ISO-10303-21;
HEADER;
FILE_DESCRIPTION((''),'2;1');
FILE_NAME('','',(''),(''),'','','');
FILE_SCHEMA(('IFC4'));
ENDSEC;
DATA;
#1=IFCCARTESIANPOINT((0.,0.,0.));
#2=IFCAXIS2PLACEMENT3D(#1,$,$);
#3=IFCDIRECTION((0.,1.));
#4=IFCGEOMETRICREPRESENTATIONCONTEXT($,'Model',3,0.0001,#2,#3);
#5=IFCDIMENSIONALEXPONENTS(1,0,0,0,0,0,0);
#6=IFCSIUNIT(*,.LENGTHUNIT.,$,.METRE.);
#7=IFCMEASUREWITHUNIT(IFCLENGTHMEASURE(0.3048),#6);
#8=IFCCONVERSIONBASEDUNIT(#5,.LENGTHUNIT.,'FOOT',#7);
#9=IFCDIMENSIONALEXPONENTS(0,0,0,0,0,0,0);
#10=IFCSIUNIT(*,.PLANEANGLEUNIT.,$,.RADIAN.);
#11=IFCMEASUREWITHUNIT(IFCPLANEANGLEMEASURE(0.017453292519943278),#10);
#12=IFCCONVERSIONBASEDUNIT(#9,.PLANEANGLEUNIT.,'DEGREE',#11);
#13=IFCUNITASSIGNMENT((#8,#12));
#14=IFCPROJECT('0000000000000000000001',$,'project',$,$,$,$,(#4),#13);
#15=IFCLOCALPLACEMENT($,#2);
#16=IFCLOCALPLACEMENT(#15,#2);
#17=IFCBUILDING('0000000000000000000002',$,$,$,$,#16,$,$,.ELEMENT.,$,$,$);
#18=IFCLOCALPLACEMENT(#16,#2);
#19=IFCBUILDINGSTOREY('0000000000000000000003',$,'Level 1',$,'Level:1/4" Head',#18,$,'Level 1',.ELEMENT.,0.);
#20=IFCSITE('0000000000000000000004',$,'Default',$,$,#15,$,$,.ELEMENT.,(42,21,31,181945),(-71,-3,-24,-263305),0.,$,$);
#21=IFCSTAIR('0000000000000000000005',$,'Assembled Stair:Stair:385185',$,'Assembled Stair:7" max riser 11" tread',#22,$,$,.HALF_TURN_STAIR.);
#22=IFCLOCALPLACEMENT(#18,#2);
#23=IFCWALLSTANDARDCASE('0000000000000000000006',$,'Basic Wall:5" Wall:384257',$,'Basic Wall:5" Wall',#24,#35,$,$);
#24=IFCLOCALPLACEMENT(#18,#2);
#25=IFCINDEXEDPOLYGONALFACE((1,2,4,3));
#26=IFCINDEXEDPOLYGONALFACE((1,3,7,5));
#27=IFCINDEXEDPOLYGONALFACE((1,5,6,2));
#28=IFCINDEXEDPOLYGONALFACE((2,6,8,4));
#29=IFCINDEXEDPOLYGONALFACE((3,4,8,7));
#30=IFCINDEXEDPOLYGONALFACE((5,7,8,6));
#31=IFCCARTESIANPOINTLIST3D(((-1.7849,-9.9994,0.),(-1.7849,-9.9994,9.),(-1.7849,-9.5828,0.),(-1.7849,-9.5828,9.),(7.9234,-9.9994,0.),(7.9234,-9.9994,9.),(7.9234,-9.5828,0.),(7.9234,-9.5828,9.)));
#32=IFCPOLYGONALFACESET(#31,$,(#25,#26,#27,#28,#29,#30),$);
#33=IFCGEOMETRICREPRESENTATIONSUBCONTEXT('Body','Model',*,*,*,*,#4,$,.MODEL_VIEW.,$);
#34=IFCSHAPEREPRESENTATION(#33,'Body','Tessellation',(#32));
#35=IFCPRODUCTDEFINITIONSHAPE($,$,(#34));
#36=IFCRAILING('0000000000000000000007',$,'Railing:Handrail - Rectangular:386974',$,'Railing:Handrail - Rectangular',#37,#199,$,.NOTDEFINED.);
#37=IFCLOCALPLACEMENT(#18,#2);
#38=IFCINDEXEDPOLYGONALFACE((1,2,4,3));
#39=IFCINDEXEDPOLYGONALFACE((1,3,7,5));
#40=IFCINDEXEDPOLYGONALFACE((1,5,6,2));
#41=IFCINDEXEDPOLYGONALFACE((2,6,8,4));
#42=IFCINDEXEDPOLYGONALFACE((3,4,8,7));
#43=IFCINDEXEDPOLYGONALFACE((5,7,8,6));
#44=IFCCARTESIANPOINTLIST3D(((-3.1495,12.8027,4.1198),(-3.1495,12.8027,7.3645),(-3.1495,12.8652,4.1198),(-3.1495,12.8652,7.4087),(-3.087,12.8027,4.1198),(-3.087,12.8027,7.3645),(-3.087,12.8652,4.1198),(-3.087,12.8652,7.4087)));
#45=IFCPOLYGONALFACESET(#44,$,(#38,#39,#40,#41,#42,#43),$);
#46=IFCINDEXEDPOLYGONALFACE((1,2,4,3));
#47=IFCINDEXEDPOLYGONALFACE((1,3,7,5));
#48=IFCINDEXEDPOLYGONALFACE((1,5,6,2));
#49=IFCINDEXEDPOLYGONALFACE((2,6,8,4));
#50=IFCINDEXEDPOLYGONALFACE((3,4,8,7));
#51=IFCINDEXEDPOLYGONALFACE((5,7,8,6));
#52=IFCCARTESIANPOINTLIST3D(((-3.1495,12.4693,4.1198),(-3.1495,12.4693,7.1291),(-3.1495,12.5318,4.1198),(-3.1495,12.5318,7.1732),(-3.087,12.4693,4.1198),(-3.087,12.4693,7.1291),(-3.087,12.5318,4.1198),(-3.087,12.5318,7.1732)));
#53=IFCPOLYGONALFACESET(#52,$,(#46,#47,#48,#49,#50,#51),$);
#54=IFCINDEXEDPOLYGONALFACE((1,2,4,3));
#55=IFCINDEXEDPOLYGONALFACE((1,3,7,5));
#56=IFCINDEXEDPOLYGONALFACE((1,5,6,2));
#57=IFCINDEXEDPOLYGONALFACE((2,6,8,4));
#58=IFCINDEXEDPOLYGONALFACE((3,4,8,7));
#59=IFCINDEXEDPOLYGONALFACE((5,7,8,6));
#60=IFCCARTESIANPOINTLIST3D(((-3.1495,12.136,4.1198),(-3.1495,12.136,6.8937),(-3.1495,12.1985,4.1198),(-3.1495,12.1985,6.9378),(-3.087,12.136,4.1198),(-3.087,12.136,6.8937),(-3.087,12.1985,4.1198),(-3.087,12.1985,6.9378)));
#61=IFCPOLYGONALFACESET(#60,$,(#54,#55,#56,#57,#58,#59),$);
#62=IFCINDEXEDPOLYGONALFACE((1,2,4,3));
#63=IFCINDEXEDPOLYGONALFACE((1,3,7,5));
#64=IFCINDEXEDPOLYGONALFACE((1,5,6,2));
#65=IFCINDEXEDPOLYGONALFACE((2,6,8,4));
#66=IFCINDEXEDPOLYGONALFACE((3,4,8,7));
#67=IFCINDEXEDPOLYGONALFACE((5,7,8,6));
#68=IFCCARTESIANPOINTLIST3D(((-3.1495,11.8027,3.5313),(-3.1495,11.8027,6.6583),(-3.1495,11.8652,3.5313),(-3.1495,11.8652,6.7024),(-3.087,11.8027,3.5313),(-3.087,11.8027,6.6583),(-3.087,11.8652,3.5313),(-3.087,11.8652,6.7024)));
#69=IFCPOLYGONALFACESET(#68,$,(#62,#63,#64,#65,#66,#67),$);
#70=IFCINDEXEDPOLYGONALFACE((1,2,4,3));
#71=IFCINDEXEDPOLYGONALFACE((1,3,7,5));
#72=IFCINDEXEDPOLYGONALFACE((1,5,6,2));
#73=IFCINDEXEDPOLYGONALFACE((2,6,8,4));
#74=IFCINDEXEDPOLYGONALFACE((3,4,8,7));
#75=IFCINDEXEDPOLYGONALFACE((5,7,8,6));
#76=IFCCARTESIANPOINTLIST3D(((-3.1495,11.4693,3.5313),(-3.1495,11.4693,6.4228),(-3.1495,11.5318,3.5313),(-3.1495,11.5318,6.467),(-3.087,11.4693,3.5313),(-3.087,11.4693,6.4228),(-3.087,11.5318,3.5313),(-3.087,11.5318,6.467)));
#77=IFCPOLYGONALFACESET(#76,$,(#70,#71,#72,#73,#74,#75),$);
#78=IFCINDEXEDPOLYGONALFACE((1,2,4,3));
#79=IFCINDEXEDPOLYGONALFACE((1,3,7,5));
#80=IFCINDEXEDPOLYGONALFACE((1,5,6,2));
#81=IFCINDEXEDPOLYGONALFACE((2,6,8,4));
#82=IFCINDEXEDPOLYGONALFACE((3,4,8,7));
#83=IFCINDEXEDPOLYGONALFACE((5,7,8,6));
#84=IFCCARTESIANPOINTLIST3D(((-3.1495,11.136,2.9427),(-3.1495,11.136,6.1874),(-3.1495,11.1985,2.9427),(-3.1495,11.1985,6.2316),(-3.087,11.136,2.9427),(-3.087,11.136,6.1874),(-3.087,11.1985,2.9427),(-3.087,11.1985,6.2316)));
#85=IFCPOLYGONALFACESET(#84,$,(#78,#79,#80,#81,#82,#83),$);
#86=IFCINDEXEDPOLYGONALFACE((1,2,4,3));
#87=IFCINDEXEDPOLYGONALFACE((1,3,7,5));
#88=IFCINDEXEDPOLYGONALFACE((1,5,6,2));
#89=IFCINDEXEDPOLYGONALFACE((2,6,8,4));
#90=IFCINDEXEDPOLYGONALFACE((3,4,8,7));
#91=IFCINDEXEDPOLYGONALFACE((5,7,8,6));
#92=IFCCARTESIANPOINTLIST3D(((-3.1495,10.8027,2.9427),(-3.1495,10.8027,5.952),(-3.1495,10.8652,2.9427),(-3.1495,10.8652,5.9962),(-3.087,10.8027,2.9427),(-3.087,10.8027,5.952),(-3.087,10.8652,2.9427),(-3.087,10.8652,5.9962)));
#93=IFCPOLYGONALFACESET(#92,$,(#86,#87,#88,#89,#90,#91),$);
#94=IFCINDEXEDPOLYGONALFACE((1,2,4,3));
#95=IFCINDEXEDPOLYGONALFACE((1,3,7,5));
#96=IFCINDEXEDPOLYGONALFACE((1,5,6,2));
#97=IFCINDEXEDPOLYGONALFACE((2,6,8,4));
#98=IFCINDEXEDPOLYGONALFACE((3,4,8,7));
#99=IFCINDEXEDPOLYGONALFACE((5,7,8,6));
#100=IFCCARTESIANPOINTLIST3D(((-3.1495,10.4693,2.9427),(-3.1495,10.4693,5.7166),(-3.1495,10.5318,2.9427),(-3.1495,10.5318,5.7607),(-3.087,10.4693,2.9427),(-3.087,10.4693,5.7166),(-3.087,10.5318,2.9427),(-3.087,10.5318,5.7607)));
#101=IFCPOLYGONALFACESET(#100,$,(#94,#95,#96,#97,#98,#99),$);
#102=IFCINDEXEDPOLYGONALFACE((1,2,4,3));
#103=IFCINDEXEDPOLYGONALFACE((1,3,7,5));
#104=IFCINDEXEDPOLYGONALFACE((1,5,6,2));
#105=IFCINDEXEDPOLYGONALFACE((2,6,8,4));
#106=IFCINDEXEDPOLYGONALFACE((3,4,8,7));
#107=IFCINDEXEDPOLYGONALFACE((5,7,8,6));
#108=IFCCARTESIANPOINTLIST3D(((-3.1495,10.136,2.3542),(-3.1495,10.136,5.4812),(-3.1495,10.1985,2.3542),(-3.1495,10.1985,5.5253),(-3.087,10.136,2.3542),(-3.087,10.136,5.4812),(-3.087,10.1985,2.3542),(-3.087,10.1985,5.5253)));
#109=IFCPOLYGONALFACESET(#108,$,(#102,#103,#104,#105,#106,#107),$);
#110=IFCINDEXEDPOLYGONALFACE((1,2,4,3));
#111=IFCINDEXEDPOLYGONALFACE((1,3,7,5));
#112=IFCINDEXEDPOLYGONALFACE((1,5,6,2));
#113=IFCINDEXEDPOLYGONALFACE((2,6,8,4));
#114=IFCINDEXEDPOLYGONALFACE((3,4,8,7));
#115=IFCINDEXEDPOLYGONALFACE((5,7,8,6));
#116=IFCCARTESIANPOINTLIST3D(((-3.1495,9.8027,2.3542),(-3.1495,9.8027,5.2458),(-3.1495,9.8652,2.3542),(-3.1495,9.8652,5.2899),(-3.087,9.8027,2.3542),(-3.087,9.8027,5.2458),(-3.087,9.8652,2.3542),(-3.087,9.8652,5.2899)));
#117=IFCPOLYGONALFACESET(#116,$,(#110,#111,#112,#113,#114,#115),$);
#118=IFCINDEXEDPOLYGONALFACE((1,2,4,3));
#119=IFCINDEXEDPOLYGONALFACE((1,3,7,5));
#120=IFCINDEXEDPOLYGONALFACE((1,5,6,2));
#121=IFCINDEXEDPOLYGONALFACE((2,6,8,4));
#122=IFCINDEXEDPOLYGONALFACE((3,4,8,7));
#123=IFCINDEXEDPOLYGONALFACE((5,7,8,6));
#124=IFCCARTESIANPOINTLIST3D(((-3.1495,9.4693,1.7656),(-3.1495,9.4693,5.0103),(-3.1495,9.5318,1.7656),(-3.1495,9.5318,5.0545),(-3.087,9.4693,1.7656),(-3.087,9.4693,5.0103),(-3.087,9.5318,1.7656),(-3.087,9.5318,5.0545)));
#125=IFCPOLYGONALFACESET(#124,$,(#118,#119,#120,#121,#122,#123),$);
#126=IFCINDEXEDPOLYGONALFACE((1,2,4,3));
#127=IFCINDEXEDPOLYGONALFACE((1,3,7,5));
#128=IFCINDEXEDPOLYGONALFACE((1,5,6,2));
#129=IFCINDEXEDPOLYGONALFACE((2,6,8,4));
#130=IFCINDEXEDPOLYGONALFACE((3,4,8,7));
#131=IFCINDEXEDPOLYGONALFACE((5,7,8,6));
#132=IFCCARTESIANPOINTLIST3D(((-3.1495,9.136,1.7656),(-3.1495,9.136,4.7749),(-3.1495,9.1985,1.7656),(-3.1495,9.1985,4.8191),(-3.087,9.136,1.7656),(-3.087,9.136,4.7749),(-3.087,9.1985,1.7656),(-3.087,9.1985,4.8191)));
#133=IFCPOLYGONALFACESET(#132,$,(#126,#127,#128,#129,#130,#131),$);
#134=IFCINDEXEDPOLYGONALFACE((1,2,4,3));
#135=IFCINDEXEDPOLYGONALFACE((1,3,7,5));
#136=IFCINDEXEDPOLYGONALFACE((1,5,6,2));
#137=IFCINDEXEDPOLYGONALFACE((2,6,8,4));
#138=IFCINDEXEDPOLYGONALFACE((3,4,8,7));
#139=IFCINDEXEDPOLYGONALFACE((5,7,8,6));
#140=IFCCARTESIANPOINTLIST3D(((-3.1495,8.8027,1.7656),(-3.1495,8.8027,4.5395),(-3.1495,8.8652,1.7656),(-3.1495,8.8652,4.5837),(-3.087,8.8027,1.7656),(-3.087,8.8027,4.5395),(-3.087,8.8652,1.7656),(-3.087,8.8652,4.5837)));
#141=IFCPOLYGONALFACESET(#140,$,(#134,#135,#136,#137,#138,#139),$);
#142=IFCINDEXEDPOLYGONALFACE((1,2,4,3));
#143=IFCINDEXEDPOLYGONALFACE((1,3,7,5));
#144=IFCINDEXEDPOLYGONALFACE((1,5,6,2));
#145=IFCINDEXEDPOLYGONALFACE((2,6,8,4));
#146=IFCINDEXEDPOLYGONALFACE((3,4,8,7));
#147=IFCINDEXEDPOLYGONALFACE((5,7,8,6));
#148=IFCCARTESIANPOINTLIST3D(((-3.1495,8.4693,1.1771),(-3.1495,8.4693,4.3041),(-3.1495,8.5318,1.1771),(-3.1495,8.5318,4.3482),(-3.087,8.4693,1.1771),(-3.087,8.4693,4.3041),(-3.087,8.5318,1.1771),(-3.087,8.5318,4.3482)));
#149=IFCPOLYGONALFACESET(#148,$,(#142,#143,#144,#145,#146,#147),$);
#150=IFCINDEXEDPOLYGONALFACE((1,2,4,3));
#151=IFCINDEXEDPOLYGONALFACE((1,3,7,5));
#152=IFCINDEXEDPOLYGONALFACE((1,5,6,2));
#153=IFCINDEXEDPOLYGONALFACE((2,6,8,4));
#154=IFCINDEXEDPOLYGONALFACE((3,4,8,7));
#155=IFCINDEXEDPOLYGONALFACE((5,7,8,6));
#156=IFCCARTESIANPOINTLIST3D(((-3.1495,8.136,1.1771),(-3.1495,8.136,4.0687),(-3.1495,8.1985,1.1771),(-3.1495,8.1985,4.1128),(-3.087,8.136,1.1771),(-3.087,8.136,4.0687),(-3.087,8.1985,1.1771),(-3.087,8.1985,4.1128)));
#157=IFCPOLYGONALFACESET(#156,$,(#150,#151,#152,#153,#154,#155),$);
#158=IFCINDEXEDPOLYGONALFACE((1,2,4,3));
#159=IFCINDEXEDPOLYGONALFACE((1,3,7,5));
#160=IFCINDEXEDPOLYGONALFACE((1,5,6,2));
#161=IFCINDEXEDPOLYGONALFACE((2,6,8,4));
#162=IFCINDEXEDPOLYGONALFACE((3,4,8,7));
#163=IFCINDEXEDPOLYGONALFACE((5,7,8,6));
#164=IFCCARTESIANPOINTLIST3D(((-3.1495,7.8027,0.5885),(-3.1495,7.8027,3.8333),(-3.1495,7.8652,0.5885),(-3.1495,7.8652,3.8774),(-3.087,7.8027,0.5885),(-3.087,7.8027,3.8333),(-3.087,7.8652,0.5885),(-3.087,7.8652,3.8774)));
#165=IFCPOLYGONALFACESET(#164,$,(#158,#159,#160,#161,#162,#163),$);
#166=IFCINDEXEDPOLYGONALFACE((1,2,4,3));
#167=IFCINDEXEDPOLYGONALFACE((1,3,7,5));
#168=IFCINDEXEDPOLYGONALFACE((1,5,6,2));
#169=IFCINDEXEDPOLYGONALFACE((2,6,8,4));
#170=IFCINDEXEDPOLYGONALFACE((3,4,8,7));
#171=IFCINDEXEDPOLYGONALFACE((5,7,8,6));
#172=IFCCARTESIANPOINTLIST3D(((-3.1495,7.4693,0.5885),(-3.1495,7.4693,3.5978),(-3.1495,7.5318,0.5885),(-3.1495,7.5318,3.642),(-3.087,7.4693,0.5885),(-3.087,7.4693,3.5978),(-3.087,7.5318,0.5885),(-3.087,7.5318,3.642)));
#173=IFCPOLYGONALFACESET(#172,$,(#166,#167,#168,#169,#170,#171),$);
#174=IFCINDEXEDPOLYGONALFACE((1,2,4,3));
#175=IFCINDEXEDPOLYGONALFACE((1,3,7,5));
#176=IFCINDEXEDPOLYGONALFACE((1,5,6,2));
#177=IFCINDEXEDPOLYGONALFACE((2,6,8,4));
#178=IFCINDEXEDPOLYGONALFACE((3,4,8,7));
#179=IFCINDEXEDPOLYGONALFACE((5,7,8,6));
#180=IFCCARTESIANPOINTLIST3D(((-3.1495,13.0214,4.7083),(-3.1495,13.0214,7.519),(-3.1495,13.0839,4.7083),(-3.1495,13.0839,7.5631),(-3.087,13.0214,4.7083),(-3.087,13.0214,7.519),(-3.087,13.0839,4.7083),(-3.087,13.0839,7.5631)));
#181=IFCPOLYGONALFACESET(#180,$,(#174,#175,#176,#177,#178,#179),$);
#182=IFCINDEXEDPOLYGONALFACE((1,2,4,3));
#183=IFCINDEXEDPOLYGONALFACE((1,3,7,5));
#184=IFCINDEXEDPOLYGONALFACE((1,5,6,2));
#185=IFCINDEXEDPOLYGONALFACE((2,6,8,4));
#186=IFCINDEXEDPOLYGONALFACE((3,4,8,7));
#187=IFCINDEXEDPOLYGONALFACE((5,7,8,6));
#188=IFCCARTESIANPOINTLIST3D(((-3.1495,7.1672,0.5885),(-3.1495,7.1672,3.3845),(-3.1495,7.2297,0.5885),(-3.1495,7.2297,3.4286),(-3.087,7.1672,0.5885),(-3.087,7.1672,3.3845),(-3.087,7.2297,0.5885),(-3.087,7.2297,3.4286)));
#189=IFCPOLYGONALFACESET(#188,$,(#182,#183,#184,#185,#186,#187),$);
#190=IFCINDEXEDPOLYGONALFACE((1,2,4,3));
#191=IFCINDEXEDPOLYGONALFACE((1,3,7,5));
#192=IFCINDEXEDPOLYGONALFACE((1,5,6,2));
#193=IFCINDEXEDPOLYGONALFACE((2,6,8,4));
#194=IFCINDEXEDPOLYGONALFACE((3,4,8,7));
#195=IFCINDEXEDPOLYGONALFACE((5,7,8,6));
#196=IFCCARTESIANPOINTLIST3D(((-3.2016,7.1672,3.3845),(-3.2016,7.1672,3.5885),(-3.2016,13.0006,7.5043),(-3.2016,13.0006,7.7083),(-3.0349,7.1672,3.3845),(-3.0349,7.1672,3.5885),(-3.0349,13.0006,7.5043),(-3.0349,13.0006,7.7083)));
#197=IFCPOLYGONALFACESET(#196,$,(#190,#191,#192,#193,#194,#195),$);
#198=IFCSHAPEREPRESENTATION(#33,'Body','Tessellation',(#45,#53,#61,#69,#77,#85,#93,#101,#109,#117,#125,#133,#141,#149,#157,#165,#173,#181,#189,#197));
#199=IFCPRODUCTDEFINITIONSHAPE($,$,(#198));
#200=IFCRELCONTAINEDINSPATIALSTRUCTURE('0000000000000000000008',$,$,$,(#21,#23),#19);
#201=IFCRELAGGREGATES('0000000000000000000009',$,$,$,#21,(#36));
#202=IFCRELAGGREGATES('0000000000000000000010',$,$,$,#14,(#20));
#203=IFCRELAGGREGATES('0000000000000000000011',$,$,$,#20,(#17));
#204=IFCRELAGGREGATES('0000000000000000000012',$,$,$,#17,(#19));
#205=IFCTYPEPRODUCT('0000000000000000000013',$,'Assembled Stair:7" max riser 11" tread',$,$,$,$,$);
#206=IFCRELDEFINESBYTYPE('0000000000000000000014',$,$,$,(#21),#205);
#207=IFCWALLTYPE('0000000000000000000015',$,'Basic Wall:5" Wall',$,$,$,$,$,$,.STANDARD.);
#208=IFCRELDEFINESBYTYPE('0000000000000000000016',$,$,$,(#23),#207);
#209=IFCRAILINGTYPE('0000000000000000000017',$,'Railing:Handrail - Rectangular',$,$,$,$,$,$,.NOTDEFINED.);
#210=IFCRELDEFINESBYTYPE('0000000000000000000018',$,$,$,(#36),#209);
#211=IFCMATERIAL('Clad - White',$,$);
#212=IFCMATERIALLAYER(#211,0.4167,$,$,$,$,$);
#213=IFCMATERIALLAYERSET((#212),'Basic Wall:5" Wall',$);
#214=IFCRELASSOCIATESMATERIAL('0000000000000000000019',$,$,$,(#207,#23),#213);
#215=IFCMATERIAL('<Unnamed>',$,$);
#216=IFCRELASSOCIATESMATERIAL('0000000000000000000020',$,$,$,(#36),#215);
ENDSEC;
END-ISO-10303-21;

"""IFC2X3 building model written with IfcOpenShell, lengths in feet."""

from ifc_helpers import new_model, entity, si_unit, converted_unit, direction, frame, frame_2d, origin, place, context, subcontext, project, spatial, polyline, rectangle, outline, extrude, clip, bounded_halfspace, material, layer, layer_set, layer_usage, type_object, element, aggregate, save


model = new_model("IFC2X3")

# Units and contexts
model_context = context("Model", 3, precision=0.0001, world=origin(), true_north=direction((0.0, 1.0)))
body_context = subcontext(model_context, "Body", "Model", "MODEL_VIEW")
ifc_project = project(units=[converted_unit("LENGTHUNIT", "FOOT", entity("IfcLengthMeasure", 0.3048), si_unit("LENGTHUNIT", "METRE"), dimensions=[1, 0, 0, 0, 0, 0, 0]), converted_unit("PLANEANGLEUNIT", "DEGREE", entity("IfcPlaneAngleMeasure", 0.017453292519943278), si_unit("PLANEANGLEUNIT", "RADIAN"), dimensions=[0, 0, 0, 0, 0, 0, 0])], contexts=[model_context])

# Site, building, storey
site_placement = place(None, origin())
site = spatial("IfcSite", under=ifc_project, at=site_placement, Name="Default", CompositionType="ELEMENT", RefLatitude=(42, 21, 31, 181945), RefLongitude=(-71, -3, -24, -263305), RefElevation=0.0)
building_placement = place(site_placement, origin())
building = spatial("IfcBuilding", under=site, at=building_placement, CompositionType="ELEMENT")
storey_placement = place(building_placement, origin())
storey = spatial("IfcBuildingStorey", under=building, at=storey_placement, Name="Level 1", ObjectType="Level:1/4\" Head", LongName="Level 1", CompositionType="ELEMENT", Elevation=0.0)

# Stair
type_product = type_object("IfcTypeProduct", Name="Assembled Stair:7\" max riser 11\" tread")
stair_placement = place(storey_placement, origin())
stair = element("IfcStair", 1, at=stair_placement, inside=storey, type_object=type_product, Name="Assembled Stair:Stair:385185", ObjectType="Assembled Stair:7\" max riser 11\" tread", ShapeType="HALF_TURN_STAIR")
ifc_material_1 = material(Name="<Unnamed>")

# Shared definitions
ifc_material_2 = material(Name="Clad - White")

# Wall
ifc_layer_1 = layer(ifc_material_2, 0.4167)
ifc_layer_set_1 = layer_set([ifc_layer_1], Name="Basic Wall:5\" Wall")
ifc_layer_usage_1 = layer_usage(ifc_layer_set_1, "AXIS2", "NEGATIVE", 0.2083)
wall_type_1 = type_object("IfcWallType", Name="Basic Wall:5\" Wall", PredefinedType="STANDARD", material=ifc_layer_set_1)
wall_1_placement = place(storey_placement, frame((7.9234, -9.7911, 0.0), z_axis=(0.0, 0.0, 1.0), x_axis=(-1.0, 0.0, 0.0)))
element("IfcWallStandardCase", 2, at=wall_1_placement, inside=storey, type_object=wall_type_1, material=ifc_layer_usage_1, Name="Basic Wall:5\" Wall:384257", ObjectType="Basic Wall:5\" Wall", context=body_context, shape_type="Clipping", body=[
    clip(extrude(rectangle(XDim=9.7083, YDim=0.4167, at=frame_2d((4.8542, 0.0), x_axis=(-1.0, 0.0))), origin(), (0.0, 0.0, 1.0), 9.0), bounded_halfspace(frame((0.0, -0.2083, 9.0), z_axis=(0.0, 0.0, -1.0), x_axis=(0.0, 1.0, 0.0)), True, frame((0.0, -0.2083, 9.0)), polyline([(0.0, 0.0), (9.7083, 0.0), (9.7083, 0.4167), (0.0, 0.4167), (0.0, 0.0)]))),
])

# Railing
railing_type = type_object("IfcRailingType", Name="Railing:Handrail - Rectangular", PredefinedType="NOTDEFINED")
railing_1_placement = place(stair_placement, origin())
railing_1 = element("IfcRailing", 3, at=railing_1_placement, type_object=railing_type, material=ifc_material_1, Name="Railing:Handrail - Rectangular:386974", ObjectType="Railing:Handrail - Rectangular", PredefinedType="NOTDEFINED", context=body_context, shape_type="SweptSolid", body=[
    extrude(outline(polyline([(-1.6113, -0.0312), (1.6334, -0.0312), (1.6334, 0.0312), (-1.6555, 0.0312), (-1.6113, -0.0312)])), frame((-3.1495, 12.8339, 5.7532), z_axis=(1.0, 0.0, 0.0), x_axis=(0.0, 0.0, -1.0)), (0.0, 0.0, 1.0), 0.0625),
    extrude(outline(polyline([(-1.4936, -0.0312), (1.5157, -0.0312), (1.5157, 0.0312), (-1.5378, 0.0312), (-1.4936, -0.0312)])), frame((-3.1495, 12.5006, 5.6355), z_axis=(1.0, 0.0, 0.0), x_axis=(0.0, 0.0, -1.0)), (0.0, 0.0, 1.0), 0.0625),
    extrude(outline(polyline([(-1.3759, -0.0312), (1.398, -0.0312), (1.398, 0.0312), (-1.42, 0.0312), (-1.3759, -0.0312)])), frame((-3.1495, 12.1672, 5.5178), z_axis=(1.0, 0.0, 0.0), x_axis=(0.0, 0.0, -1.0)), (0.0, 0.0, 1.0), 0.0625),
    extrude(outline(polyline([(-1.5525, -0.0312), (1.5745, -0.0312), (1.5745, 0.0312), (-1.5966, 0.0312), (-1.5525, -0.0312)])), frame((-3.1495, 11.8339, 5.1058), z_axis=(1.0, 0.0, 0.0), x_axis=(0.0, 0.0, -1.0)), (0.0, 0.0, 1.0), 0.0625),
    extrude(outline(polyline([(-1.4348, -0.0312), (1.4568, -0.0312), (1.4568, 0.0312), (-1.4789, 0.0312), (-1.4348, -0.0312)])), frame((-3.1495, 11.5006, 4.9881), z_axis=(1.0, 0.0, 0.0), x_axis=(0.0, 0.0, -1.0)), (0.0, 0.0, 1.0), 0.0625),
    extrude(outline(polyline([(-1.6113, -0.0312), (1.6334, -0.0312), (1.6334, 0.0312), (-1.6555, 0.0312), (-1.6113, -0.0312)])), frame((-3.1495, 11.1672, 4.5761), z_axis=(1.0, 0.0, 0.0), x_axis=(0.0, 0.0, -1.0)), (0.0, 0.0, 1.0), 0.0625),
    extrude(outline(polyline([(-1.4936, -0.0312), (1.5157, -0.0312), (1.5157, 0.0312), (-1.5378, 0.0312), (-1.4936, -0.0312)])), frame((-3.1495, 10.8339, 4.4584), z_axis=(1.0, 0.0, 0.0), x_axis=(0.0, 0.0, -1.0)), (0.0, 0.0, 1.0), 0.0625),
    extrude(outline(polyline([(-1.3759, -0.0312), (1.398, -0.0312), (1.398, 0.0312), (-1.42, 0.0312), (-1.3759, -0.0312)])), frame((-3.1495, 10.5006, 4.3407), z_axis=(1.0, 0.0, 0.0), x_axis=(0.0, 0.0, -1.0)), (0.0, 0.0, 1.0), 0.0625),
    extrude(outline(polyline([(-1.5525, -0.0312), (1.5745, -0.0312), (1.5745, 0.0312), (-1.5966, 0.0312), (-1.5525, -0.0312)])), frame((-3.1495, 10.1672, 3.9287), z_axis=(1.0, 0.0, 0.0), x_axis=(0.0, 0.0, -1.0)), (0.0, 0.0, 1.0), 0.0625),
    extrude(outline(polyline([(-1.4348, -0.0312), (1.4568, -0.0312), (1.4568, 0.0312), (-1.4789, 0.0312), (-1.4348, -0.0312)])), frame((-3.1495, 9.8339, 3.811), z_axis=(1.0, 0.0, 0.0), x_axis=(0.0, 0.0, -1.0)), (0.0, 0.0, 1.0), 0.0625),
    extrude(outline(polyline([(-1.6113, -0.0312), (1.6334, -0.0312), (1.6334, 0.0312), (-1.6555, 0.0312), (-1.6113, -0.0312)])), frame((-3.1495, 9.5006, 3.399), z_axis=(1.0, 0.0, 0.0), x_axis=(0.0, 0.0, -1.0)), (0.0, 0.0, 1.0), 0.0625),
    extrude(outline(polyline([(-1.4936, -0.0312), (1.5157, -0.0312), (1.5157, 0.0312), (-1.5378, 0.0312), (-1.4936, -0.0312)])), frame((-3.1495, 9.1672, 3.2813), z_axis=(1.0, 0.0, 0.0), x_axis=(0.0, 0.0, -1.0)), (0.0, 0.0, 1.0), 0.0625),
    extrude(outline(polyline([(-1.3759, -0.0312), (1.398, -0.0312), (1.398, 0.0312), (-1.42, 0.0312), (-1.3759, -0.0312)])), frame((-3.1495, 8.8339, 3.1636), z_axis=(1.0, 0.0, 0.0), x_axis=(0.0, 0.0, -1.0)), (0.0, 0.0, 1.0), 0.0625),
    extrude(outline(polyline([(-1.5525, -0.0312), (1.5745, -0.0312), (1.5745, 0.0312), (-1.5966, 0.0312), (-1.5525, -0.0312)])), frame((-3.1495, 8.5006, 2.7516), z_axis=(1.0, 0.0, 0.0), x_axis=(0.0, 0.0, -1.0)), (0.0, 0.0, 1.0), 0.0625),
    extrude(outline(polyline([(-1.4348, -0.0312), (1.4568, -0.0312), (1.4568, 0.0312), (-1.4789, 0.0312), (-1.4348, -0.0312)])), frame((-3.1495, 8.1672, 2.6339), z_axis=(1.0, 0.0, 0.0), x_axis=(0.0, 0.0, -1.0)), (0.0, 0.0, 1.0), 0.0625),
    extrude(outline(polyline([(-1.6113, -0.0312), (1.6334, -0.0312), (1.6334, 0.0312), (-1.6555, 0.0312), (-1.6113, -0.0312)])), frame((-3.1495, 7.8339, 2.2219), z_axis=(1.0, 0.0, 0.0), x_axis=(0.0, 0.0, -1.0)), (0.0, 0.0, 1.0), 0.0625),
    extrude(outline(polyline([(-1.4936, -0.0312), (1.5157, -0.0312), (1.5157, 0.0312), (-1.5378, 0.0312), (-1.4936, -0.0312)])), frame((-3.1495, 7.5006, 2.1042), z_axis=(1.0, 0.0, 0.0), x_axis=(0.0, 0.0, -1.0)), (0.0, 0.0, 1.0), 0.0625),
    extrude(outline(polyline([(-1.3943, -0.0312), (1.4164, -0.0312), (1.4164, 0.0312), (-1.4384, 0.0312), (-1.3943, -0.0312)])), frame((-3.1495, 13.0527, 6.1247), z_axis=(1.0, 0.0, 0.0), x_axis=(0.0, 0.0, -1.0)), (0.0, 0.0, 1.0), 0.0625),
    extrude(outline(polyline([(-1.3869, -0.0312), (1.409, -0.0312), (1.409, 0.0312), (-1.4311, 0.0312), (-1.3869, -0.0312)])), frame((-3.1495, 7.1985, 1.9976), z_axis=(1.0, 0.0, 0.0), x_axis=(0.0, 0.0, -1.0)), (0.0, 0.0, 1.0), 0.0625),
    extrude(outline(polyline([(-3.6296, -0.0833), (3.5119, -0.0833), (3.6296, 0.0833), (-3.5119, 0.0833), (-3.6296, -0.0833)])), frame((-3.2016, 10.0839, 5.5464), z_axis=(1.0, 0.0, 0.0), x_axis=(0.0, 0.816826, 0.576884)), (0.0, 0.0, 1.0), 0.1667),
])
aggregate(stair, [railing_1])

save(model, "model.ifc")
